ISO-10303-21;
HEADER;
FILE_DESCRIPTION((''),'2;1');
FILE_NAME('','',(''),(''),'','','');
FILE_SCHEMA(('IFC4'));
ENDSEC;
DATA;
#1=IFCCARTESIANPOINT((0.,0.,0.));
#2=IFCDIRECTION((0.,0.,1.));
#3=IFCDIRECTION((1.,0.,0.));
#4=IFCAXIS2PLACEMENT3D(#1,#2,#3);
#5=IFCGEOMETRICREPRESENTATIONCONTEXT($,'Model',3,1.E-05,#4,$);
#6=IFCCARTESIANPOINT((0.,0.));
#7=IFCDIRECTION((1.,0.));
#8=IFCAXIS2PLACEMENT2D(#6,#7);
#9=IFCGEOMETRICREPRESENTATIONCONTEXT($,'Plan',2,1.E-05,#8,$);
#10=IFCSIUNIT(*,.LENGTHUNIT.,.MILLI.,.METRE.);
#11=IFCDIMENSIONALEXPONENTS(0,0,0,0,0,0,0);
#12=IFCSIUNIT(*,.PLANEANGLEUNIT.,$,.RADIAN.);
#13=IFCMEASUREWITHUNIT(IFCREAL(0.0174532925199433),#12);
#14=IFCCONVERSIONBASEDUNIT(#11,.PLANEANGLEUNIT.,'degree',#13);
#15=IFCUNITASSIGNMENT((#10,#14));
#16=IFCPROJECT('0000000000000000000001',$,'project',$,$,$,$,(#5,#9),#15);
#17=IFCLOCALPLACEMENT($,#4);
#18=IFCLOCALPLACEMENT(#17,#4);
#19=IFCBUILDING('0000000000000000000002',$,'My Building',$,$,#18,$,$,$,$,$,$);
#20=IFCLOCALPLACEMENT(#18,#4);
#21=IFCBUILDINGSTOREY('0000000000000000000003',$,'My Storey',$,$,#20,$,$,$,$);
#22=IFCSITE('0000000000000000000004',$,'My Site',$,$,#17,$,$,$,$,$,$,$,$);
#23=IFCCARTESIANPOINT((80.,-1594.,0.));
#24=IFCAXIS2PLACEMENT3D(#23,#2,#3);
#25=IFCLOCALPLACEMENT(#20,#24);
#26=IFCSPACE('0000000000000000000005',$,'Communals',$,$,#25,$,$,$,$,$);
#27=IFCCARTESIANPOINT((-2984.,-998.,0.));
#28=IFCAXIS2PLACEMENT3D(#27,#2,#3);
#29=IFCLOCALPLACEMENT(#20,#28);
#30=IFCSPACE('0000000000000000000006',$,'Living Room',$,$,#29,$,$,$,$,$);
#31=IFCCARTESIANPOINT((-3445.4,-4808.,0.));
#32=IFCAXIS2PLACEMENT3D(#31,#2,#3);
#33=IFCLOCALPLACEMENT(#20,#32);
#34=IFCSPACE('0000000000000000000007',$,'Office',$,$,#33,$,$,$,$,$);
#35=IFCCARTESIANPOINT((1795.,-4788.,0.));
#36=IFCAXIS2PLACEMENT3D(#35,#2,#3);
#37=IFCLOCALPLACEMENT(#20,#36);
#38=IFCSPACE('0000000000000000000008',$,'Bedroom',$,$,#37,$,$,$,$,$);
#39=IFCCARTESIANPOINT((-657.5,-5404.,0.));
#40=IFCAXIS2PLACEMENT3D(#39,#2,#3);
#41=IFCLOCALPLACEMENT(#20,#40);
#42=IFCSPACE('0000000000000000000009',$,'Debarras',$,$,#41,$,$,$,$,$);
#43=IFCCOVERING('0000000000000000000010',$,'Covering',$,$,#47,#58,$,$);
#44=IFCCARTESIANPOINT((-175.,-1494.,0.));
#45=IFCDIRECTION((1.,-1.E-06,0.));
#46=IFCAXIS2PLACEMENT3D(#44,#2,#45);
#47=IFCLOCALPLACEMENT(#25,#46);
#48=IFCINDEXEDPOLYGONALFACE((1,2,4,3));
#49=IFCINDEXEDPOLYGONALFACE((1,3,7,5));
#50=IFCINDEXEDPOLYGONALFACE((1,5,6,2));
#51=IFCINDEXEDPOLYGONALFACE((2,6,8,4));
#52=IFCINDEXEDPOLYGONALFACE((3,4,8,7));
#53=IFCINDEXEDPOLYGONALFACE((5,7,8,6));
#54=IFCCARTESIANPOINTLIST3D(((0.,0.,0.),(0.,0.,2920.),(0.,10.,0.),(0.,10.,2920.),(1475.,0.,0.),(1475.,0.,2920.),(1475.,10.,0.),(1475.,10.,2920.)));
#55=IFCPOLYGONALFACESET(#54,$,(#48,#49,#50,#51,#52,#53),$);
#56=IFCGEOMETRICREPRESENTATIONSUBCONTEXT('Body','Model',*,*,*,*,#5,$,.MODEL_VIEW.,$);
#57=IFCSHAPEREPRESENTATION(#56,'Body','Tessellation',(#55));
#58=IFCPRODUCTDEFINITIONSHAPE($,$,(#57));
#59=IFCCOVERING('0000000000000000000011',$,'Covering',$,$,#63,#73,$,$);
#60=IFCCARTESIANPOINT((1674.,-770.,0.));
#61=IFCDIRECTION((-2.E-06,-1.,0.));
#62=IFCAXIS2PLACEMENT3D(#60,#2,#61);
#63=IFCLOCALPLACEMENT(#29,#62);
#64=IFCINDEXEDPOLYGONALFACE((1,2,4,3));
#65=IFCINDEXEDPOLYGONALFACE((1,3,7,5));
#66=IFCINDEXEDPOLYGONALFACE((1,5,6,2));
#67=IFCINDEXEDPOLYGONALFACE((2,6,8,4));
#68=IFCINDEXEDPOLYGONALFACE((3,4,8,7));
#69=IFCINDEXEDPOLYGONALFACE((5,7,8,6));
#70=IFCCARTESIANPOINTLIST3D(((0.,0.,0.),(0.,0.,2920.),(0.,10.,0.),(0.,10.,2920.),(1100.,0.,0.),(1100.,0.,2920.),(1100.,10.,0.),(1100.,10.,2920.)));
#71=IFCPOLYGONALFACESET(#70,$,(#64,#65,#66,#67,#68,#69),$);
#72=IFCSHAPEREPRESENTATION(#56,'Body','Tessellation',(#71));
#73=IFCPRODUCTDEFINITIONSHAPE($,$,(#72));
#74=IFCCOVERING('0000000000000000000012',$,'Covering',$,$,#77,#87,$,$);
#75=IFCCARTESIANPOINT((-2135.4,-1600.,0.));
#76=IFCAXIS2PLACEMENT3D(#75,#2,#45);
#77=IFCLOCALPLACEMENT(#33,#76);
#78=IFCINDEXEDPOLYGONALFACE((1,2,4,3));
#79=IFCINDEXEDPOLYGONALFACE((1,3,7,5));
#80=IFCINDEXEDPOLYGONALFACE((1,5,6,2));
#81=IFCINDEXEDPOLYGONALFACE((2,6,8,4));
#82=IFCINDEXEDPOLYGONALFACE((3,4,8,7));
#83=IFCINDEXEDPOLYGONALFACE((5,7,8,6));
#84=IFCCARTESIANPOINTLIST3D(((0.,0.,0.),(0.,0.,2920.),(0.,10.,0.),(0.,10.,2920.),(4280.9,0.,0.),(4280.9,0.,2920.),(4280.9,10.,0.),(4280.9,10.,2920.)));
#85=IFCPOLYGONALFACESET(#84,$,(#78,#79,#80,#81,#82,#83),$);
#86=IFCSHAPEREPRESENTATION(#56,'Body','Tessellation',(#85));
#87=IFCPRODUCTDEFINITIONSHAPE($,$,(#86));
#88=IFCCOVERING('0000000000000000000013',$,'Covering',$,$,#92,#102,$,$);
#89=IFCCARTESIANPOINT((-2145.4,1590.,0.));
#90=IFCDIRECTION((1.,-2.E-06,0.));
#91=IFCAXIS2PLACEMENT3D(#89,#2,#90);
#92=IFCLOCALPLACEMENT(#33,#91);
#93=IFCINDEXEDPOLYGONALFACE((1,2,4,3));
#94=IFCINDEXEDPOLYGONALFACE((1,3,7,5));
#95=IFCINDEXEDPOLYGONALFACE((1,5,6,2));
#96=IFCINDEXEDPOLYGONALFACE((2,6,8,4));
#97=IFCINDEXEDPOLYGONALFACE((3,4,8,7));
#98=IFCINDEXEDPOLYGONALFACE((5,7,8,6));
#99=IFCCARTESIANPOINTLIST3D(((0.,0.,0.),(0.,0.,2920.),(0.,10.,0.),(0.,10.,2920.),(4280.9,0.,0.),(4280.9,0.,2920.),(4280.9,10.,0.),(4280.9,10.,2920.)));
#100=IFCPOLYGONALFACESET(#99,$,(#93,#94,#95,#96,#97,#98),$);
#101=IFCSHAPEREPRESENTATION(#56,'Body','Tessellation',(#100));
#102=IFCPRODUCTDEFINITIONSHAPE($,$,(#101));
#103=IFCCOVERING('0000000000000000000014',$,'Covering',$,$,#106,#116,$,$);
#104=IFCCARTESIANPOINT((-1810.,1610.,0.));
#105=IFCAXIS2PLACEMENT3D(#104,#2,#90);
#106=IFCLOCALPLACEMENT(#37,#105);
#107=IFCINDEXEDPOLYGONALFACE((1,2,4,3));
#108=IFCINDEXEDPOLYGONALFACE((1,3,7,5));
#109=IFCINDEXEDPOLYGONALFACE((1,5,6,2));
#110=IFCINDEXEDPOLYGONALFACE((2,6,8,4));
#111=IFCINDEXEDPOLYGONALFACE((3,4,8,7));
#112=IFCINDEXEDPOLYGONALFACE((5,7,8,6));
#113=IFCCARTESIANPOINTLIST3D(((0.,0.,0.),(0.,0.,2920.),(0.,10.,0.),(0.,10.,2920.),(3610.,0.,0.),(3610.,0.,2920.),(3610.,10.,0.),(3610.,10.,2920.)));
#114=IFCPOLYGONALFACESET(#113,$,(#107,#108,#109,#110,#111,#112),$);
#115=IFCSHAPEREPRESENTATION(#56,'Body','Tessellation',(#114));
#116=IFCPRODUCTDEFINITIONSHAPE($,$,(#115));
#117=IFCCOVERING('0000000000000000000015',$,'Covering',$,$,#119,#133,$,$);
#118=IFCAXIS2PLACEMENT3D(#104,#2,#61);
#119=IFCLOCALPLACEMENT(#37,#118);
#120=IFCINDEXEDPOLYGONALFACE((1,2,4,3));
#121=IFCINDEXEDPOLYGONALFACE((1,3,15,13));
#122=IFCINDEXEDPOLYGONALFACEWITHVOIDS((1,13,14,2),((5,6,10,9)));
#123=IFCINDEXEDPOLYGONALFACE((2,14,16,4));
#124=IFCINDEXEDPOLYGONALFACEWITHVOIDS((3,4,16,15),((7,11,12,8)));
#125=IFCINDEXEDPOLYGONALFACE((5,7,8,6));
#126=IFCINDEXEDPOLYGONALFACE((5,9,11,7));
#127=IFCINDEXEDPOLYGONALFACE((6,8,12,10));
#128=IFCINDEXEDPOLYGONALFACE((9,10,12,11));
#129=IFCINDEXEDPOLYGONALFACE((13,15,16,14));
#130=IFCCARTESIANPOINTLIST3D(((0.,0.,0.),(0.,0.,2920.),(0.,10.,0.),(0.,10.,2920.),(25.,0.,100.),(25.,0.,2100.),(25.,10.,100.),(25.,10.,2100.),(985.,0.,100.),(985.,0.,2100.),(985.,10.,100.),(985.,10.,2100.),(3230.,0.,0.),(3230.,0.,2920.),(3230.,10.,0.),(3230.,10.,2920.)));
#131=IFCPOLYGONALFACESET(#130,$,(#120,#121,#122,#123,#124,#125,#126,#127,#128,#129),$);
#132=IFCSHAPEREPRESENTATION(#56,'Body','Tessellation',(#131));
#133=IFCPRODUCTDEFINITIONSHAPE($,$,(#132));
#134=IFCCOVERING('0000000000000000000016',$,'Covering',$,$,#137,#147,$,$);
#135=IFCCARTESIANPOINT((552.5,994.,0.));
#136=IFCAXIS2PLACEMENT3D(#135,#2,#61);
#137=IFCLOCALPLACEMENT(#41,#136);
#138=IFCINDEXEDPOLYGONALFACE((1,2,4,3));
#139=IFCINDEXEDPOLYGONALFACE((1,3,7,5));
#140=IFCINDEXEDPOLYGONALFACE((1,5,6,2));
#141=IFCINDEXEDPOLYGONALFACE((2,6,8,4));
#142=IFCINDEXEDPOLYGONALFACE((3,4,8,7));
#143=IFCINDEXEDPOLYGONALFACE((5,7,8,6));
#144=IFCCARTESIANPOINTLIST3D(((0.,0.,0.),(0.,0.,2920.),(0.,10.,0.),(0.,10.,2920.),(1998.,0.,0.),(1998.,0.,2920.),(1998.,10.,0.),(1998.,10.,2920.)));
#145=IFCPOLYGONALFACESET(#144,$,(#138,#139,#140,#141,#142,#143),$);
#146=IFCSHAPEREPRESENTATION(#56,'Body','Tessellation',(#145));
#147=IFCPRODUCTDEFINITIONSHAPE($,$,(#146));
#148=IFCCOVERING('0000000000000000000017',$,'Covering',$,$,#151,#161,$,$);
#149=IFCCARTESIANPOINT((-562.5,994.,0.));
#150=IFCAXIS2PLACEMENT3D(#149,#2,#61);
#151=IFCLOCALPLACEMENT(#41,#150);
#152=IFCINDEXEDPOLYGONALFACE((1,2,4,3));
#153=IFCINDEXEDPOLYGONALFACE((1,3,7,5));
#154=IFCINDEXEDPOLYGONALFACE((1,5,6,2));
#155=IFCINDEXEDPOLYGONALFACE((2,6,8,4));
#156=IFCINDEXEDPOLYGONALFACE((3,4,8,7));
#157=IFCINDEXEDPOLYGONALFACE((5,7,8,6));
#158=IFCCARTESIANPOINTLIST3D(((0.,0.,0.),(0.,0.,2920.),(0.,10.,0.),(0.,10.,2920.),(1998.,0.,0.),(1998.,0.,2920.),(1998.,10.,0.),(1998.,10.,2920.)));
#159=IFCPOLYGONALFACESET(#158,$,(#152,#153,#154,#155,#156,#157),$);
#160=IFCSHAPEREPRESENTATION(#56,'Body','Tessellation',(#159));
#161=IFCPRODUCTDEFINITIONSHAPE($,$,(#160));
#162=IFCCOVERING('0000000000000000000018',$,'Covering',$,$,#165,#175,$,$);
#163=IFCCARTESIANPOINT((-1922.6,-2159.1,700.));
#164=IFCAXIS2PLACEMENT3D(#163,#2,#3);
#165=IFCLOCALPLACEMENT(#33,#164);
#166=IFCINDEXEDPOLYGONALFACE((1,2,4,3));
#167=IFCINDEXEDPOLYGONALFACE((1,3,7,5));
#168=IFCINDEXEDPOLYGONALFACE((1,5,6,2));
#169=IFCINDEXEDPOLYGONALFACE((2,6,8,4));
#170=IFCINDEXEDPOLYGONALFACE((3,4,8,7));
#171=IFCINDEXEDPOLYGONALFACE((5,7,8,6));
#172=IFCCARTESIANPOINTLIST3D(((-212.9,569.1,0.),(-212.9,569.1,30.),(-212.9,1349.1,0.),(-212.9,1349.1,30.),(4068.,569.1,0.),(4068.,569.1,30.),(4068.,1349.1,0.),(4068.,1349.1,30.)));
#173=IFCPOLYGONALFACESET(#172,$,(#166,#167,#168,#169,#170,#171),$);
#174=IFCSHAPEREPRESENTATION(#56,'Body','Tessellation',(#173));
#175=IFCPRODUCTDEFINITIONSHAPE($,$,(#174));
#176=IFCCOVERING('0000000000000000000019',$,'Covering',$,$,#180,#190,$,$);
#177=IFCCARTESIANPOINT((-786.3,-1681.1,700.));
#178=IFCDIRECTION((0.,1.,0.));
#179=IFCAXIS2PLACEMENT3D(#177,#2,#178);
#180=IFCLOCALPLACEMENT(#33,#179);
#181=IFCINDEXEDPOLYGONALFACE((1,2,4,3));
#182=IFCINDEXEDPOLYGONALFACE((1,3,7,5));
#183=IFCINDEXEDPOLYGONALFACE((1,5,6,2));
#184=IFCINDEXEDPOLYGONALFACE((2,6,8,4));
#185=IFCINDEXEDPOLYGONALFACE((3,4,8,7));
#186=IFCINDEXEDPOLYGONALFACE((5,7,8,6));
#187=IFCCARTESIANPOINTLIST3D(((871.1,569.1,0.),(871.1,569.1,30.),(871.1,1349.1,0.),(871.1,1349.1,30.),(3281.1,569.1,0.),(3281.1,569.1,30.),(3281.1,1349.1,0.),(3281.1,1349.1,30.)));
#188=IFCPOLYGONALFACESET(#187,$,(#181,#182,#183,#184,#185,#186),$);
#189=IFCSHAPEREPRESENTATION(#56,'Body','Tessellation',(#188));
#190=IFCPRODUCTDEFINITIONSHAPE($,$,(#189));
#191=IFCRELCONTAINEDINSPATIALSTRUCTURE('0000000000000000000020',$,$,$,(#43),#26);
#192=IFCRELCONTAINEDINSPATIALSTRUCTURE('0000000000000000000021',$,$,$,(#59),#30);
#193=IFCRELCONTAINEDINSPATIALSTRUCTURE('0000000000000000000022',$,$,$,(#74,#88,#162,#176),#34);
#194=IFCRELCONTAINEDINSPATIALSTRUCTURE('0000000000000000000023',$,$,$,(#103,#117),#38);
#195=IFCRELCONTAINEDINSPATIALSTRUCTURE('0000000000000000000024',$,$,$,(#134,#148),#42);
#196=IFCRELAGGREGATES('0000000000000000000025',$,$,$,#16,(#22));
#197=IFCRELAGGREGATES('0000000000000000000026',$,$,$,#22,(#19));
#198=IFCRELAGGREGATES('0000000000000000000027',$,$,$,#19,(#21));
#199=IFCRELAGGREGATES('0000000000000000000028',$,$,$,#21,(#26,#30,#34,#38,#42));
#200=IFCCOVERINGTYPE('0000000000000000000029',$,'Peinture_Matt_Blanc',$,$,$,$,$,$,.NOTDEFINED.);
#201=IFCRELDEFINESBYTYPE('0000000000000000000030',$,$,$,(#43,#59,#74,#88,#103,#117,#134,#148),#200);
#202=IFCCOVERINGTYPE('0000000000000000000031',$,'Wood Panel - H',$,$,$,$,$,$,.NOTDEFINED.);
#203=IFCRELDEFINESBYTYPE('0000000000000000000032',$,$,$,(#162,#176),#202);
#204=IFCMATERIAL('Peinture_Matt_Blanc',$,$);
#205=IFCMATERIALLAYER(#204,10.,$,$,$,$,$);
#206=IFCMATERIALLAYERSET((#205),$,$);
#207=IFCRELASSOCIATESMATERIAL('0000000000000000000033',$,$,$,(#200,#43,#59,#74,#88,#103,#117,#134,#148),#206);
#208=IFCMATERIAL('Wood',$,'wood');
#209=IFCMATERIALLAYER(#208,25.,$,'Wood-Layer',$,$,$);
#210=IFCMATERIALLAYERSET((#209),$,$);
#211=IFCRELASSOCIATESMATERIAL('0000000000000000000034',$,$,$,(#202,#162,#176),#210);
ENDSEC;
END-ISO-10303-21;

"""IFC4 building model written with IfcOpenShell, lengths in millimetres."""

from ifc_helpers import new_model, entity, si_unit, converted_unit, frame, origin_with_axes, origin_2d_with_axis, place, context, subcontext, project, spatial, line, indexed_curve, outline, extrude, clip, halfspace, source, transform, mapped, material, layer, layer_set, layer_usage, type_object, element, save


model = new_model("IFC4")

# Units and contexts
model_context = context("Model", 3, precision=1e-05, world=origin_with_axes())
plan_context = context("Plan", 2, precision=1e-05, world=origin_2d_with_axis())
body_context_1 = subcontext(model_context, "Body", "Model", "MODEL_VIEW")
ifc_project = project(units=[si_unit("LENGTHUNIT", "METRE", prefix="MILLI"), converted_unit("PLANEANGLEUNIT", "degree", entity("IfcReal", 0.0174532925199433), si_unit("PLANEANGLEUNIT", "RADIAN"), dimensions=[0, 0, 0, 0, 0, 0, 0])], contexts=[model_context, plan_context])

# Site, building, storey
site_placement = place(None, origin_with_axes())
site = spatial("IfcSite", under=ifc_project, at=site_placement, Name="My Site")
building_placement = place(site_placement, origin_with_axes())
building = spatial("IfcBuilding", under=site, at=building_placement, Name="My Building")
storey_placement = place(building_placement, origin_with_axes())
storey = spatial("IfcBuildingStorey", under=building, at=storey_placement, Name="My Storey")

# Shared definitions
shared_shape_1 = source(origin_with_axes(), body_context_1, "Body", "SweptSolid", [
    extrude(outline(indexed_curve([(0.0, 0.0), (960.0, 0.0), (960.0, 2000.0), (0.0, 2000.0)], segments=[line(1, 2, 3, 4, 1)])), frame((0.0, -100.0, 0.0), z_axis=(0.0, -1.0, 0.0), x_axis=(1.0, 0.0, 0.0)), (0.0, 0.0, -1.0), 280.0),
])

# Shared definitions
space_1_placement = place(storey_placement, frame((80.0, -1594.0, 0.0), z_axis=(0.0, 0.0, 1.0), x_axis=(1.0, 0.0, 0.0)))
space_1 = spatial("IfcSpace", under=storey, at=space_1_placement, Name="Communals")

# Covering
ifc_material_1 = material(Name="Peinture_Matt_Blanc")
ifc_layer_1 = layer(ifc_material_1, 10.0)
ifc_layer_set_1 = layer_set([ifc_layer_1])
ifc_layer_usage_1 = layer_usage(ifc_layer_set_1, "AXIS2", "POSITIVE", 0.0)
covering_type_1 = type_object("IfcCoveringType", Name="Peinture_Matt_Blanc", PredefinedType="NOTDEFINED", material=ifc_layer_set_1)
covering_1_placement = place(space_1_placement, frame((-175.0, -1494.0, 0.0), z_axis=(0.0, 0.0, 1.0), x_axis=(1.0, -0.000001, 0.0)))
element("IfcCovering", 1, at=covering_1_placement, inside=space_1, type_object=covering_type_1, material=ifc_layer_usage_1, Name="Covering", context=body_context_1, shape_type="Clipping", body=[
    clip(extrude(outline(indexed_curve([(0.0, 0.0), (0.0, 10.0), (1475.0, 10.0), (1475.0, 0.0), (0.0, 0.0)], self_intersect=False)), origin_with_axes(), (0.0, 0.0, 1.0), 2920.0), halfspace(frame((0.0, 0.0, 2920.0), z_axis=(0.0, 0.0, 1.0), x_axis=(-1.0, 0.0, 0.0)), False)),
])

# Shared definitions
space_2_placement = place(storey_placement, frame((-2984.0, -998.0, 0.0), z_axis=(0.0, 0.0, 1.0), x_axis=(1.0, 0.0, 0.0)))
space_2 = spatial("IfcSpace", under=storey, at=space_2_placement, Name="Living Room")

# Covering
ifc_layer_usage_2 = layer_usage(ifc_layer_set_1, "AXIS2", "POSITIVE", 0.0)
covering_2_placement = place(space_2_placement, frame((1674.0, -770.0, 0.0), z_axis=(0.0, 0.0, 1.0), x_axis=(-0.000002, -1.0, 0.0)))
element("IfcCovering", 2, at=covering_2_placement, inside=space_2, type_object=covering_type_1, material=ifc_layer_usage_2, Name="Covering", context=body_context_1, shape_type="Clipping", body=[
    clip(extrude(outline(indexed_curve([(0.0, 0.0), (0.0, 10.0), (1100.0, 10.0), (1100.0, 0.0), (0.0, 0.0)], self_intersect=False)), origin_with_axes(), (0.0, 0.0, 1.0), 2920.0), halfspace(frame((0.0, 0.0, 2920.0), z_axis=(0.0, 0.0, 1.0), x_axis=(-1.0, 0.0, 0.0)), False)),
])

# Shared definitions
space_3_placement = place(storey_placement, frame((-3445.4, -4808.0, 0.0), z_axis=(0.0, 0.0, 1.0), x_axis=(1.0, 0.0, 0.0)))
space_3 = spatial("IfcSpace", under=storey, at=space_3_placement, Name="Office")

# Covering
ifc_layer_usage_3 = layer_usage(ifc_layer_set_1, "AXIS2", "POSITIVE", 0.0)
covering_3_placement = place(space_3_placement, frame((-2135.4, -1600.0, 0.0), z_axis=(0.0, 0.0, 1.0), x_axis=(1.0, -0.000001, 0.0)))
element("IfcCovering", 3, at=covering_3_placement, inside=space_3, type_object=covering_type_1, material=ifc_layer_usage_3, Name="Covering", context=body_context_1, shape_type="Clipping", body=[
    clip(extrude(outline(indexed_curve([(0.0, 0.0), (0.0, 10.0), (4280.9, 10.0), (4280.9, 0.0), (0.0, 0.0)], self_intersect=False)), origin_with_axes(), (0.0, 0.0, 1.0), 2920.0), halfspace(frame((0.0, 0.0, 2920.0), z_axis=(0.0, 0.0, 1.0), x_axis=(-1.0, 0.0, 0.0)), False)),
])

# Covering
ifc_layer_usage_4 = layer_usage(ifc_layer_set_1, "AXIS2", "POSITIVE", 0.0)
covering_4_placement = place(space_3_placement, frame((-2145.4, 1590.0, 0.0), z_axis=(0.0, 0.0, 1.0), x_axis=(1.0, -0.000002, 0.0)))
element("IfcCovering", 4, at=covering_4_placement, inside=space_3, type_object=covering_type_1, material=ifc_layer_usage_4, Name="Covering", context=body_context_1, shape_type="Clipping", body=[
    clip(extrude(outline(indexed_curve([(0.0, 0.0), (0.0, 10.0), (4280.9, 10.0), (4280.9, 0.0), (0.0, 0.0)], self_intersect=False)), origin_with_axes(), (0.0, 0.0, 1.0), 2920.0), halfspace(frame((0.0, 0.0, 2920.0), z_axis=(0.0, 0.0, 1.0), x_axis=(-1.0, 0.0, 0.0)), False)),
])

# Shared definitions
space_4_placement = place(storey_placement, frame((1795.0, -4788.0, 0.0), z_axis=(0.0, 0.0, 1.0), x_axis=(1.0, 0.0, 0.0)))
space_4 = spatial("IfcSpace", under=storey, at=space_4_placement, Name="Bedroom")

# Covering
ifc_layer_usage_5 = layer_usage(ifc_layer_set_1, "AXIS2", "POSITIVE", 0.0)
covering_5_placement = place(space_4_placement, frame((-1810.0, 1610.0, 0.0), z_axis=(0.0, 0.0, 1.0), x_axis=(1.0, -0.000002, 0.0)))
element("IfcCovering", 5, at=covering_5_placement, inside=space_4, type_object=covering_type_1, material=ifc_layer_usage_5, Name="Covering", context=body_context_1, shape_type="Clipping", body=[
    clip(clip(extrude(outline(indexed_curve([(0.0, 0.0), (0.0, 10.0), (3610.0, 10.0), (3610.0, 0.0), (0.0, 0.0)], self_intersect=False)), origin_with_axes(), (0.0, 0.0, 1.0), 2920.0), halfspace(frame((0.0, 0.0, 2920.0), z_axis=(0.0, 0.0, 1.0), x_axis=(-1.0, 0.0, 0.0)), False)), halfspace(frame((0.0, 0.0, 2920.0), z_axis=(0.0, 0.0, 1.0), x_axis=(-1.0, 0.0, 0.0)), False)),
])

# Covering, opening
ifc_layer_usage_6 = layer_usage(ifc_layer_set_1, "AXIS2", "POSITIVE", 0.0)
covering_6_placement = place(space_4_placement, frame((-1810.0, 1610.0, 0.0), z_axis=(0.0, 0.0, 1.0), x_axis=(-0.000002, -1.0, 0.0)))
covering_6 = element("IfcCovering", 6, at=covering_6_placement, inside=space_4, type_object=covering_type_1, material=ifc_layer_usage_6, Name="Covering", context=body_context_1, shape_type="Clipping", body=[
    clip(extrude(outline(indexed_curve([(0.0, 0.0), (0.0, 10.0), (3230.0, 10.0), (3230.0, 0.0), (0.0, 0.0)], self_intersect=False)), origin_with_axes(), (0.0, 0.0, 1.0), 2920.0), halfspace(frame((0.0, 0.0, 2920.0), z_axis=(0.0, 0.0, 1.0), x_axis=(-1.0, 0.0, 0.0)), False)),
])
opening_1_placement = place(covering_6_placement, frame((25.0, -82.5, 100.0), z_axis=(0.0, 0.0, 1.0), x_axis=(1.0, 0.000002, 0.0)))
element("IfcOpeningElement", 7, at=opening_1_placement, cuts=covering_6, PredefinedType="OPENING", context=body_context_1, shape_type="MappedRepresentation", body=[
    mapped(shared_shape_1, transform((0.0, 0.0, 0.0), x_axis=(1.0, 0.0, 0.0), y_axis=(0.0, 1.0, 0.0), z_axis=(0.0, 0.0, 1.0), scale=1.0)),
])

# Shared definitions
space_5_placement = place(storey_placement, frame((-657.5, -5404.0, 0.0), z_axis=(0.0, 0.0, 1.0), x_axis=(1.0, 0.0, 0.0)))
space_5 = spatial("IfcSpace", under=storey, at=space_5_placement, Name="Debarras")

# Coverings
ifc_layer_usage_7 = layer_usage(ifc_layer_set_1, "AXIS2", "POSITIVE", 0.0)
covering_7_placement = place(space_5_placement, frame((552.5, 994.0, 0.0), z_axis=(0.0, 0.0, 1.0), x_axis=(-0.000002, -1.0, 0.0)))
element("IfcCovering", 8, at=covering_7_placement, inside=space_5, type_object=covering_type_1, material=ifc_layer_usage_7, Name="Covering", context=body_context_1, shape_type="Clipping", body=[
    clip(extrude(outline(indexed_curve([(0.0, 0.0), (0.0, 10.0), (1998.0, 10.0), (1998.0, 0.0), (0.0, 0.0)], self_intersect=False)), origin_with_axes(), (0.0, 0.0, 1.0), 2920.0), halfspace(frame((0.0, 0.0, 2920.0), z_axis=(0.0, 0.0, 1.0), x_axis=(-1.0, 0.0, 0.0)), False)),
])
ifc_layer_usage_8 = layer_usage(ifc_layer_set_1, "AXIS2", "POSITIVE", 0.0)
covering_8_placement = place(space_5_placement, frame((-562.5, 994.0, 0.0), z_axis=(0.0, 0.0, 1.0), x_axis=(-0.000002, -1.0, 0.0)))
element("IfcCovering", 9, at=covering_8_placement, inside=space_5, type_object=covering_type_1, material=ifc_layer_usage_8, Name="Covering", context=body_context_1, shape_type="Clipping", body=[
    clip(extrude(outline(indexed_curve([(0.0, 0.0), (0.0, 10.0), (1998.0, 10.0), (1998.0, 0.0), (0.0, 0.0)], self_intersect=False)), origin_with_axes(), (0.0, 0.0, 1.0), 2920.0), halfspace(frame((0.0, 0.0, 2920.0), z_axis=(0.0, 0.0, 1.0), x_axis=(-1.0, 0.0, 0.0)), False)),
])
ifc_material_2 = material(Name="Wood", Category="wood")
ifc_layer_2 = layer(ifc_material_2, 25.0, Name="Wood-Layer")
ifc_layer_set_2 = layer_set([ifc_layer_2])
ifc_layer_usage_9 = layer_usage(ifc_layer_set_2, "AXIS3", "POSITIVE", 0.0)
covering_type_2 = type_object("IfcCoveringType", Name="Wood Panel - H", PredefinedType="NOTDEFINED", material=ifc_layer_set_2)
covering_9_placement = place(space_3_placement, frame((-1922.6, -2159.1, 700.0), z_axis=(0.0, 0.0, 1.0), x_axis=(1.0, 0.0, 0.0)))
element("IfcCovering", 10, at=covering_9_placement, inside=space_3, type_object=covering_type_2, material=ifc_layer_usage_9, Name="Covering", context=body_context_1, shape_type="SweptSolid", body=[
    extrude(outline(indexed_curve([(4068.0, 1349.1), (4068.0, 569.1), (-212.9, 569.1), (-212.9, 1349.1)], segments=[line(4, 1), line(1, 2), line(2, 3), line(3, 4)], self_intersect=False)), None, (0.0, 0.0, 1.0), 30.0),
])
ifc_layer_usage_10 = layer_usage(ifc_layer_set_2, "AXIS3", "POSITIVE", 0.0)
covering_10_placement = place(space_3_placement, frame((-786.3, -1681.1, 700.0), z_axis=(0.0, 0.0, 1.0), x_axis=(0.0, 1.0, 0.0)))
element("IfcCovering", 11, at=covering_10_placement, inside=space_3, type_object=covering_type_2, material=ifc_layer_usage_10, Name="Covering", context=body_context_1, shape_type="SweptSolid", body=[
    extrude(outline(indexed_curve([(871.1, 1349.1), (3281.1, 1349.1), (3281.1, 569.1), (871.1, 569.1)], segments=[line(3, 2), line(2, 1), line(1, 4), line(4, 3)], self_intersect=False)), None, (0.0, 0.0, 1.0), 30.0),
])

save(model, "model.ifc")
